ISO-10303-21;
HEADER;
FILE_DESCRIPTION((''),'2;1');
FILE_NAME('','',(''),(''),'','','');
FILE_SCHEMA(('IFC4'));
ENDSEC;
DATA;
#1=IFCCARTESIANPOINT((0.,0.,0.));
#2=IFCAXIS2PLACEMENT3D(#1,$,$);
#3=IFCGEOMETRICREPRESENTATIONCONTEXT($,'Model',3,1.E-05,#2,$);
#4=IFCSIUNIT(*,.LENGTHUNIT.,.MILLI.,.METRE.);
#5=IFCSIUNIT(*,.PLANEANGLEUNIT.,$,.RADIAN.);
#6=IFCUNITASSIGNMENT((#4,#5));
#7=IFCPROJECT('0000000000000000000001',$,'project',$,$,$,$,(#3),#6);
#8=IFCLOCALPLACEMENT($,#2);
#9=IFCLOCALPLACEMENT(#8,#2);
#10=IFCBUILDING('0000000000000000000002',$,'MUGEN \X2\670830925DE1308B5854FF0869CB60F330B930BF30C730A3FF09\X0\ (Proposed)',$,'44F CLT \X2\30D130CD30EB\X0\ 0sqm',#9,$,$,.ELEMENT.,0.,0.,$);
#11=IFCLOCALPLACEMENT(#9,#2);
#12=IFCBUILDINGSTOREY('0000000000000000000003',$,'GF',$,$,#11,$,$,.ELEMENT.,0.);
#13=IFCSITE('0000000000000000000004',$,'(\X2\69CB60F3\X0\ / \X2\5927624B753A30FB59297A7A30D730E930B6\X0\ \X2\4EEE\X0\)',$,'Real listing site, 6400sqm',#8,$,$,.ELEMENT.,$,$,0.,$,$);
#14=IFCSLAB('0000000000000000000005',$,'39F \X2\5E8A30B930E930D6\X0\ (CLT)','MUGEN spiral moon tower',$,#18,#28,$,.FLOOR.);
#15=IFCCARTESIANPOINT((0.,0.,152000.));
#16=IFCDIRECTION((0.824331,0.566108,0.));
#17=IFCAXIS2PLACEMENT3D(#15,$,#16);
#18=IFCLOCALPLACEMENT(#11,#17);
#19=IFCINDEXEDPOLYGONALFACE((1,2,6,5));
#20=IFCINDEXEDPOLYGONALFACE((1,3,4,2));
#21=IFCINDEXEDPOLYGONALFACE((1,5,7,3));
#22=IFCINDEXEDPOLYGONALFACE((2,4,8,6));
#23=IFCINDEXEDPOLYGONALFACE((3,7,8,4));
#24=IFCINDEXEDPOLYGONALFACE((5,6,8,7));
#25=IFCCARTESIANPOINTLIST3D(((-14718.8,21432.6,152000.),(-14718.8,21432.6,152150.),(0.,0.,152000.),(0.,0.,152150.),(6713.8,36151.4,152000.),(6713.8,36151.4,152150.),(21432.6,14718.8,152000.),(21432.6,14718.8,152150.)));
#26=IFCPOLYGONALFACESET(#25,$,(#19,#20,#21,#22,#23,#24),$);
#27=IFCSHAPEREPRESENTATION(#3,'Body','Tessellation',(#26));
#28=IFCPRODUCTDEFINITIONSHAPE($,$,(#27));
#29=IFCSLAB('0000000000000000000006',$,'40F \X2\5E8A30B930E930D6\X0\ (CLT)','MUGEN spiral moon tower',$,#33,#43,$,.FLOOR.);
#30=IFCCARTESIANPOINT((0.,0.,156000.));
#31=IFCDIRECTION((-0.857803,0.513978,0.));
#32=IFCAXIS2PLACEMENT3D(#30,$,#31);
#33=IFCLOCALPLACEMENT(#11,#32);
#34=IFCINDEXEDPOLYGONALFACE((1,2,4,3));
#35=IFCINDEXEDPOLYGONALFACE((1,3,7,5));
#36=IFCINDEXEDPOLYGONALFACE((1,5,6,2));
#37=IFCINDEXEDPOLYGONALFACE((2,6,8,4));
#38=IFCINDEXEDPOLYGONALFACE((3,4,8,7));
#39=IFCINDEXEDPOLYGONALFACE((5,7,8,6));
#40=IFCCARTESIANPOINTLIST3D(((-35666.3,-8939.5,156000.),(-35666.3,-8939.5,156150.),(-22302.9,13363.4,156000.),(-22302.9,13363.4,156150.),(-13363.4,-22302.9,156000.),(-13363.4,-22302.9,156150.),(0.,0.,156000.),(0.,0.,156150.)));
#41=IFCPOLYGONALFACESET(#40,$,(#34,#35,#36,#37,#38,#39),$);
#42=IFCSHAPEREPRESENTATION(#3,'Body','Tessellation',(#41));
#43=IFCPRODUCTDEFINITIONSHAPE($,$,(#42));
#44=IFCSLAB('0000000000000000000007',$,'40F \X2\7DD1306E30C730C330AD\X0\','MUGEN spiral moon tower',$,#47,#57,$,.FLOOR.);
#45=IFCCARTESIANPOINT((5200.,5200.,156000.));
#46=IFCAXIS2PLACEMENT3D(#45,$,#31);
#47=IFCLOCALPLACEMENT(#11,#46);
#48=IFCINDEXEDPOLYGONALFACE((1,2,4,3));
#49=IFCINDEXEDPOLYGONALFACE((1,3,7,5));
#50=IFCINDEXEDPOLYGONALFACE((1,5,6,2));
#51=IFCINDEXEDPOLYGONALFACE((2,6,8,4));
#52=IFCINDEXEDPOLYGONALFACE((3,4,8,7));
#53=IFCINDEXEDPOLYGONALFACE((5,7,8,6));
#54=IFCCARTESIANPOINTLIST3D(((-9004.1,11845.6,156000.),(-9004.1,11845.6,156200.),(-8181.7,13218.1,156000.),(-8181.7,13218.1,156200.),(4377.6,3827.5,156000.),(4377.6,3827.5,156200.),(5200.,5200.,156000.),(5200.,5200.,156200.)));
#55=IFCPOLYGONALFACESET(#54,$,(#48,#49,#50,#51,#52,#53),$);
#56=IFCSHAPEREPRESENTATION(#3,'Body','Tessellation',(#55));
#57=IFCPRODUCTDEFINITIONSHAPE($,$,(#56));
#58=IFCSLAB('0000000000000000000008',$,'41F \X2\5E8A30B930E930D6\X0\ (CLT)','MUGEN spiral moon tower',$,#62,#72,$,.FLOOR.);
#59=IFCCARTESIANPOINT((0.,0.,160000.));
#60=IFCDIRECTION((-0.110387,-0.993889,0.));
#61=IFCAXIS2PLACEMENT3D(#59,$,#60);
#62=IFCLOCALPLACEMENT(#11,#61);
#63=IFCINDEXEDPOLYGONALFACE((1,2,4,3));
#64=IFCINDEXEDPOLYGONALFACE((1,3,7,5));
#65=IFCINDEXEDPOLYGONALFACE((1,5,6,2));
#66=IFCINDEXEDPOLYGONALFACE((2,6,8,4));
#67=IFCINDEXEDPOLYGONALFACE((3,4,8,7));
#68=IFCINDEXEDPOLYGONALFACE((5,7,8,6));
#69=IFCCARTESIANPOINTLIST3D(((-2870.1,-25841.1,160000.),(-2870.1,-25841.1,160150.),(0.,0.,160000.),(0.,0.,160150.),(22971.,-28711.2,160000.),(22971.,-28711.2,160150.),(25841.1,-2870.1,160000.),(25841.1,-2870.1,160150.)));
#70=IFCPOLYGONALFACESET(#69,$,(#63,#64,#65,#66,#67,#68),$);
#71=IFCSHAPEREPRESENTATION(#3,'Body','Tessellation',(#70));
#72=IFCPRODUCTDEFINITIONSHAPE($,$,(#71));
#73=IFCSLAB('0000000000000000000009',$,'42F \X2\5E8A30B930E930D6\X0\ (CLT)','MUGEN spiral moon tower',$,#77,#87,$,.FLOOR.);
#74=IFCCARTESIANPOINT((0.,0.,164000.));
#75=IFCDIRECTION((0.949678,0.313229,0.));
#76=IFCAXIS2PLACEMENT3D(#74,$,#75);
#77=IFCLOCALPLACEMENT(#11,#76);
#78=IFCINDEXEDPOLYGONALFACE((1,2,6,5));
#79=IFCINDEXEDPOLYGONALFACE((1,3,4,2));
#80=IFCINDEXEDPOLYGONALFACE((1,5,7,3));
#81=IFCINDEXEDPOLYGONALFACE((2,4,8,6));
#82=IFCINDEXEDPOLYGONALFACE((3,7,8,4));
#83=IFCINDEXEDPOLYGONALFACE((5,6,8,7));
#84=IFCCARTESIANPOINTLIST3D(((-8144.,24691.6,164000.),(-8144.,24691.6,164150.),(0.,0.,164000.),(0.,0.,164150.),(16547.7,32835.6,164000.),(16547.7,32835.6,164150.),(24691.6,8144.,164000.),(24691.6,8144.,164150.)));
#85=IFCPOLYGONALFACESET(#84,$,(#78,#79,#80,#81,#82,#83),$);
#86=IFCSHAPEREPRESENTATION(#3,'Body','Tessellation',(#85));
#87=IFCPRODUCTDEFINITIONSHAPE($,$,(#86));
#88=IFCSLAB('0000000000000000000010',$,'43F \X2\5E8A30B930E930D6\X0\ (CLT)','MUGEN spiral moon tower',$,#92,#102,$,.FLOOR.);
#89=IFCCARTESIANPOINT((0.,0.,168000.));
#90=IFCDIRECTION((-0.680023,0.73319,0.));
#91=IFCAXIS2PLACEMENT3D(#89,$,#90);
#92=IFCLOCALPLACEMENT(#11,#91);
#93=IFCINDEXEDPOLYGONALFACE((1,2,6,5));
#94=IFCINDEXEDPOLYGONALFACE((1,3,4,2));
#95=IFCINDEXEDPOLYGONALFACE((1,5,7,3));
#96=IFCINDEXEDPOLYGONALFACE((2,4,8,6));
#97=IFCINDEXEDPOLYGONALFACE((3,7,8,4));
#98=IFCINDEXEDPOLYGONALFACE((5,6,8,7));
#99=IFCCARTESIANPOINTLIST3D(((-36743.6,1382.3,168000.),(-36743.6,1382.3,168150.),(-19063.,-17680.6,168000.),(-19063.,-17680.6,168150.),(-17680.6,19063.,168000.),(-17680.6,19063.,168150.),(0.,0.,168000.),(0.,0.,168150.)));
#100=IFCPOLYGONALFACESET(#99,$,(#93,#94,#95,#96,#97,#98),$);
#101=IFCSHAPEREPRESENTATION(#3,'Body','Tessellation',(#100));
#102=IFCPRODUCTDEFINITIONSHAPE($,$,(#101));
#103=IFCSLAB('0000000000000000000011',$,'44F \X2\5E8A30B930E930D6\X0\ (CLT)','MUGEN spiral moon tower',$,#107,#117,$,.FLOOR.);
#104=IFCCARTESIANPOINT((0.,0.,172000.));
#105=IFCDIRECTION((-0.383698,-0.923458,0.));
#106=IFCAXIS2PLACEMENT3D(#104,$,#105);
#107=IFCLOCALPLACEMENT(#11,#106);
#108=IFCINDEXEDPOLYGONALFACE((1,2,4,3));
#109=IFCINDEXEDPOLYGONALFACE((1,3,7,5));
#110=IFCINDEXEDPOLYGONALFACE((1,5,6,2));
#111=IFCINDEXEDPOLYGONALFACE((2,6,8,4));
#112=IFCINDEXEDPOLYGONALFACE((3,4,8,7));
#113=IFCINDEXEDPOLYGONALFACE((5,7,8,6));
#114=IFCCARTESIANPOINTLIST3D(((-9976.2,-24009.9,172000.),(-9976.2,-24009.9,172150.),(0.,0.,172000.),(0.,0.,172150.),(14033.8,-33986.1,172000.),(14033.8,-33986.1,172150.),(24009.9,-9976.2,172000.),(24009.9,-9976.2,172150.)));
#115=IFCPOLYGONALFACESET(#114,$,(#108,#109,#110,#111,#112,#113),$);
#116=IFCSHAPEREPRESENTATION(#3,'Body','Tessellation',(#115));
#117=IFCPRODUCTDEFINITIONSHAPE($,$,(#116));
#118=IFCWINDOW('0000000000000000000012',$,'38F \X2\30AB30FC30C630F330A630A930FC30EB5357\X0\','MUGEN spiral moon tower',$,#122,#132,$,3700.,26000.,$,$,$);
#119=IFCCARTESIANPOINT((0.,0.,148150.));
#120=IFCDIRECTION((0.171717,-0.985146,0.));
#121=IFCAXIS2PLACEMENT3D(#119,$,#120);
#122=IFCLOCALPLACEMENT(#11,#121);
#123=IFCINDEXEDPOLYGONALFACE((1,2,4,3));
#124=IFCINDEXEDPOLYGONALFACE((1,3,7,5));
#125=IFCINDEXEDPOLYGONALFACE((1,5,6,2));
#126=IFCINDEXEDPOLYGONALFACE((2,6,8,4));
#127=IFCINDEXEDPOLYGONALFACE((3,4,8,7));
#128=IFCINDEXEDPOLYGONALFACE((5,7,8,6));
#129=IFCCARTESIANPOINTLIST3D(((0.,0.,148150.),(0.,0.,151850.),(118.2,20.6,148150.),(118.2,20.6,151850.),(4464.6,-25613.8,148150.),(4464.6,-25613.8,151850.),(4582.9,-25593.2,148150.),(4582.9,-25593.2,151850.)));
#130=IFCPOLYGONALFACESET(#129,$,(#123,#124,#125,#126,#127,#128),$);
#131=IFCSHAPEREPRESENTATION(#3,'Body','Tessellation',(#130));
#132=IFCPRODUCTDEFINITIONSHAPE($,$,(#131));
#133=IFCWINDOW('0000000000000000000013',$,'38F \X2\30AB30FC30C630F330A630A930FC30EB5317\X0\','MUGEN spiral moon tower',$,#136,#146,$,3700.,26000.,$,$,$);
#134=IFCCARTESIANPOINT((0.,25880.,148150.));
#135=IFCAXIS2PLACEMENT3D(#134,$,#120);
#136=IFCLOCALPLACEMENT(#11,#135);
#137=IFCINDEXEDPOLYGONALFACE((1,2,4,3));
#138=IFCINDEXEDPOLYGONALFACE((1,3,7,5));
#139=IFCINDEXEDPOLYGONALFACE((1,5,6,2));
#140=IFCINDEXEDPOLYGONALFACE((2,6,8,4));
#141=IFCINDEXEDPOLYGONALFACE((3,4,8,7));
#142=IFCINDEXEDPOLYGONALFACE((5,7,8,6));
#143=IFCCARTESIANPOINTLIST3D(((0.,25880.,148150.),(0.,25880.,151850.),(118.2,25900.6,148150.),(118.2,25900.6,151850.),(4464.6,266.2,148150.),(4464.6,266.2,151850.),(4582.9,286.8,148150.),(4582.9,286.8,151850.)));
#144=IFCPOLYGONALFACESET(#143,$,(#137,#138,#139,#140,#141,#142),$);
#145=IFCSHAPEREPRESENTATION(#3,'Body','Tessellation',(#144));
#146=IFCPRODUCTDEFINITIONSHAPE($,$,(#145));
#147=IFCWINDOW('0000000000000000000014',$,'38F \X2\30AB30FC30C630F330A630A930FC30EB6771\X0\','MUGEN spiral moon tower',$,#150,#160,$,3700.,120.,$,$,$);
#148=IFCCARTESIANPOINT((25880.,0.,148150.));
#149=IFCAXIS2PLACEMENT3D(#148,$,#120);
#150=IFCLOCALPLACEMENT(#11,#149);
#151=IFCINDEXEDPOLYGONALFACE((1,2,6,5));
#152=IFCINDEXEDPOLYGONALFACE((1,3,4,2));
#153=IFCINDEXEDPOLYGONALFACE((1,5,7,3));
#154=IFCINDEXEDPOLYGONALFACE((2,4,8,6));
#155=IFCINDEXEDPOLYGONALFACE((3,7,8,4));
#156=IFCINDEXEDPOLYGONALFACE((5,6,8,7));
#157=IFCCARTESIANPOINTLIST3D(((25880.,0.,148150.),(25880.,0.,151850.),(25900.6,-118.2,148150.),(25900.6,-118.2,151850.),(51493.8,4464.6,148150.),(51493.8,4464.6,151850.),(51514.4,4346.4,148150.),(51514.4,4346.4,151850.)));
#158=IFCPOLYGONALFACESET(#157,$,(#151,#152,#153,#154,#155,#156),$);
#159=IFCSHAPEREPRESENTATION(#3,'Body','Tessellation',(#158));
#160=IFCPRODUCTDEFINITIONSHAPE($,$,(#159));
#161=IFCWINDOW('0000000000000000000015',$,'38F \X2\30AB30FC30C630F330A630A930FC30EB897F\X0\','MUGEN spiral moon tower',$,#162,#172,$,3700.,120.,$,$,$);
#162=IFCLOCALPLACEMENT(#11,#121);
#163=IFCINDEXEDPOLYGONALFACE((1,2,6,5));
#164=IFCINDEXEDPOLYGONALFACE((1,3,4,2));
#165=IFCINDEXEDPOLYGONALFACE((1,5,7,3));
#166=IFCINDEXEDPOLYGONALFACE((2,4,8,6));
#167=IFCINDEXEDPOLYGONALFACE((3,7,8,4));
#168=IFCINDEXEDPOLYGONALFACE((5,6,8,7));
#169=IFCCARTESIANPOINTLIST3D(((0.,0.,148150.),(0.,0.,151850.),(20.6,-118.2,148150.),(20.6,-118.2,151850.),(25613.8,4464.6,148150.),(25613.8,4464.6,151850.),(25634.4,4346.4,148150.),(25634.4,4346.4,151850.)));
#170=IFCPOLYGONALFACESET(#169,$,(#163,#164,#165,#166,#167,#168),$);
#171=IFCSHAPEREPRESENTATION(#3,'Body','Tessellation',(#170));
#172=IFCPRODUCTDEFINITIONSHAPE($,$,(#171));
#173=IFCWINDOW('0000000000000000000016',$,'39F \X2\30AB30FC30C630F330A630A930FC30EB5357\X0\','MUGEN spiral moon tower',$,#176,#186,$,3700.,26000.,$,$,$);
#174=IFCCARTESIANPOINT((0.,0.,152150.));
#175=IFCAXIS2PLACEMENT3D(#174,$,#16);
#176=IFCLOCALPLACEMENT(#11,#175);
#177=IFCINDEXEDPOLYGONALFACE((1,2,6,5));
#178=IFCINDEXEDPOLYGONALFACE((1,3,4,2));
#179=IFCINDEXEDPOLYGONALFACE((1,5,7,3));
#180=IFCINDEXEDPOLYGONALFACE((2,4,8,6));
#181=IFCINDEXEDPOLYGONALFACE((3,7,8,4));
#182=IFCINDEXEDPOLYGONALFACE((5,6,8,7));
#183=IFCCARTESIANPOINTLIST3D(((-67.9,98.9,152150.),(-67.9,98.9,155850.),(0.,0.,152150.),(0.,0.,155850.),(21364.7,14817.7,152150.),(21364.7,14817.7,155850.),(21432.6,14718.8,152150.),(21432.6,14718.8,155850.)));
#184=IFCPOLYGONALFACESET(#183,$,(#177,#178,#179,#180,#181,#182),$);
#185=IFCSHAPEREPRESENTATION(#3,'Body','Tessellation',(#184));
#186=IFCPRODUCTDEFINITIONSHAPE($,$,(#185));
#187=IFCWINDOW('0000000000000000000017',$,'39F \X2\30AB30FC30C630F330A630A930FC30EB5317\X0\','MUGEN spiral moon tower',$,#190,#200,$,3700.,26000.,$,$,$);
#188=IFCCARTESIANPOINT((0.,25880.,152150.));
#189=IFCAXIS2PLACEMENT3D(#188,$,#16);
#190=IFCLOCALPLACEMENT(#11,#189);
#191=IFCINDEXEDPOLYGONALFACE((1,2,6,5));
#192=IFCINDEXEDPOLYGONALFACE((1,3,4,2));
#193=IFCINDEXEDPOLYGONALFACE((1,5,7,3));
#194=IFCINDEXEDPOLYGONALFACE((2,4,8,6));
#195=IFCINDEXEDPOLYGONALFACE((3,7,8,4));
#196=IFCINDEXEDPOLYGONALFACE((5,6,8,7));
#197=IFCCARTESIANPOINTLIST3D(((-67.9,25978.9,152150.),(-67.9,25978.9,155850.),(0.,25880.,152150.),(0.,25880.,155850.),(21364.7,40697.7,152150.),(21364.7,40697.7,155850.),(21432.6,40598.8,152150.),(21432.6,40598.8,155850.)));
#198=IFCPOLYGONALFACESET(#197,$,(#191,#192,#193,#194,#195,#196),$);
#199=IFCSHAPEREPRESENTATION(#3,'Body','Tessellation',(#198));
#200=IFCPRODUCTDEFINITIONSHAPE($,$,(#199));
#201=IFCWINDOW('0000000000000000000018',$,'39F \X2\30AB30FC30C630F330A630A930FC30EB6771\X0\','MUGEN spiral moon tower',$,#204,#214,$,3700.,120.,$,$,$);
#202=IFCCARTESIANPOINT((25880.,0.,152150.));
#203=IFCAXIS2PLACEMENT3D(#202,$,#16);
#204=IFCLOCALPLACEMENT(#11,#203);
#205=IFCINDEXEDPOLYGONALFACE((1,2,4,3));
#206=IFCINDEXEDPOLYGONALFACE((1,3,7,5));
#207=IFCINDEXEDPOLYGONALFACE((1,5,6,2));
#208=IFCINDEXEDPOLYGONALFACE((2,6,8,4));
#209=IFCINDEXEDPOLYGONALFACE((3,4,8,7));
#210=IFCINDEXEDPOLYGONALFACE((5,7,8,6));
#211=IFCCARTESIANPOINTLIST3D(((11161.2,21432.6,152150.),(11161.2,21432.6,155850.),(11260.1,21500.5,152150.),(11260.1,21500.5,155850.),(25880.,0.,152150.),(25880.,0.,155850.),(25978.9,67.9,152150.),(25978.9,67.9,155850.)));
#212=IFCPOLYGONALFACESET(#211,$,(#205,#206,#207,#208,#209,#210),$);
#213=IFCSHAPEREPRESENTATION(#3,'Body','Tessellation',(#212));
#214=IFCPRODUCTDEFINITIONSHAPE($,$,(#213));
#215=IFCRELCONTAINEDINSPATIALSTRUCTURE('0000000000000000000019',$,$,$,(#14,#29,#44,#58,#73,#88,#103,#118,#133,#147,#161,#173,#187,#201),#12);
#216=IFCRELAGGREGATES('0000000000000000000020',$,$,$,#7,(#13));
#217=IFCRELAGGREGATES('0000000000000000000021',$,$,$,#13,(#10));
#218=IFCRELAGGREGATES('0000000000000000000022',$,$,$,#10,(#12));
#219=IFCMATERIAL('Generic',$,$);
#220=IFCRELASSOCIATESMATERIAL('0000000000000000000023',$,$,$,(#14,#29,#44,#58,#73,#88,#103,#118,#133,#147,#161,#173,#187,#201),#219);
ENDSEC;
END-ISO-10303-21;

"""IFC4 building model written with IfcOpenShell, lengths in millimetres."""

from ifc_helpers import new_model, si_unit, frame, frame_2d, origin, place, context, project, spatial, rectangle, extrude, material, element, save


model = new_model("IFC4")

# Units and contexts
model_context = context("Model", 3, precision=1e-05, world=origin())
ifc_project = project(units=[si_unit("LENGTHUNIT", "METRE", prefix="MILLI"), si_unit("PLANEANGLEUNIT", "RADIAN")], contexts=[model_context])

# Site, building, storey
site_placement = place(None, origin())
site = spatial("IfcSite", under=ifc_project, at=site_placement, Name="(構想 / 大手町・天空プラザ 仮)", ObjectType="Real listing site, 6400sqm", CompositionType="ELEMENT", RefElevation=0.0)
building_placement = place(site_placement, origin())
building = spatial("IfcBuilding", under=site, at=building_placement, Name="MUGEN 月を巡る塔（構想スタディ） (Proposed)", ObjectType="44F CLT パネル 0sqm", CompositionType="ELEMENT", ElevationOfRefHeight=0.0, ElevationOfTerrain=0.0)
storey_placement = place(building_placement, origin())
storey = spatial("IfcBuildingStorey", under=building, at=storey_placement, Name="GF", CompositionType="ELEMENT", Elevation=0.0)

# Slabs
ifc_material = material(Name="Generic")
slab_1_placement = place(storey_placement, frame((0.0, 0.0, 152000.0), x_axis=(0.824331, 0.566108, 0.0)))
element("IfcSlab", 1, at=slab_1_placement, inside=storey, material=ifc_material, Name="39F 床スラブ (CLT)", Description="MUGEN spiral moon tower", PredefinedType="FLOOR", context=model_context, shape_type="SweptSolid", body=[
    extrude(rectangle(XDim=26000.0, YDim=26000.0, at=frame_2d((13000.0, 13000.0))), frame((0.0, 0.0, 152000.0), x_axis=(0.824331, 0.566108, 0.0)), (0.0, 0.0, 1.0), 150.0),
])
slab_2_placement = place(storey_placement, frame((0.0, 0.0, 156000.0), x_axis=(-0.857803, 0.513978, 0.0)))
element("IfcSlab", 2, at=slab_2_placement, inside=storey, material=ifc_material, Name="40F 床スラブ (CLT)", Description="MUGEN spiral moon tower", PredefinedType="FLOOR", context=model_context, shape_type="SweptSolid", body=[
    extrude(rectangle(XDim=26000.0, YDim=26000.0, at=frame_2d((13000.0, 13000.0))), frame((0.0, 0.0, 156000.0), x_axis=(-0.857803, 0.513978, 0.0)), (0.0, 0.0, 1.0), 150.0),
])
slab_3_placement = place(storey_placement, frame((5200.0, 5200.0, 156000.0), x_axis=(-0.857803, 0.513978, 0.0)))
element("IfcSlab", 3, at=slab_3_placement, inside=storey, material=ifc_material, Name="40F 緑のデッキ", Description="MUGEN spiral moon tower", PredefinedType="FLOOR", context=model_context, shape_type="SweptSolid", body=[
    extrude(rectangle(XDim=15600.0, YDim=1600.0, at=frame_2d((7800.0, 800.0))), frame((5200.0, 5200.0, 156000.0), x_axis=(-0.857803, 0.513978, 0.0)), (0.0, 0.0, 1.0), 200.0),
])
slab_4_placement = place(storey_placement, frame((0.0, 0.0, 160000.0), x_axis=(-0.110387, -0.993889, 0.0)))
element("IfcSlab", 4, at=slab_4_placement, inside=storey, material=ifc_material, Name="41F 床スラブ (CLT)", Description="MUGEN spiral moon tower", PredefinedType="FLOOR", context=model_context, shape_type="SweptSolid", body=[
    extrude(rectangle(XDim=26000.0, YDim=26000.0, at=frame_2d((13000.0, 13000.0))), frame((0.0, 0.0, 160000.0), x_axis=(-0.110387, -0.993889, 0.0)), (0.0, 0.0, 1.0), 150.0),
])
slab_5_placement = place(storey_placement, frame((0.0, 0.0, 164000.0), x_axis=(0.949678, 0.313229, 0.0)))
element("IfcSlab", 5, at=slab_5_placement, inside=storey, material=ifc_material, Name="42F 床スラブ (CLT)", Description="MUGEN spiral moon tower", PredefinedType="FLOOR", context=model_context, shape_type="SweptSolid", body=[
    extrude(rectangle(XDim=26000.0, YDim=26000.0, at=frame_2d((13000.0, 13000.0))), frame((0.0, 0.0, 164000.0), x_axis=(0.949678, 0.313229, 0.0)), (0.0, 0.0, 1.0), 150.0),
])
slab_6_placement = place(storey_placement, frame((0.0, 0.0, 168000.0), x_axis=(-0.680023, 0.73319, 0.0)))
element("IfcSlab", 6, at=slab_6_placement, inside=storey, material=ifc_material, Name="43F 床スラブ (CLT)", Description="MUGEN spiral moon tower", PredefinedType="FLOOR", context=model_context, shape_type="SweptSolid", body=[
    extrude(rectangle(XDim=26000.0, YDim=26000.0, at=frame_2d((13000.0, 13000.0))), frame((0.0, 0.0, 168000.0), x_axis=(-0.680023, 0.73319, 0.0)), (0.0, 0.0, 1.0), 150.0),
])
slab_7_placement = place(storey_placement, frame((0.0, 0.0, 172000.0), x_axis=(-0.383698, -0.923458, 0.0)))
element("IfcSlab", 7, at=slab_7_placement, inside=storey, material=ifc_material, Name="44F 床スラブ (CLT)", Description="MUGEN spiral moon tower", PredefinedType="FLOOR", context=model_context, shape_type="SweptSolid", body=[
    extrude(rectangle(XDim=26000.0, YDim=26000.0, at=frame_2d((13000.0, 13000.0))), frame((0.0, 0.0, 172000.0), x_axis=(-0.383698, -0.923458, 0.0)), (0.0, 0.0, 1.0), 150.0),
])

# Windows
window_1_placement = place(storey_placement, frame((0.0, 0.0, 148150.0), x_axis=(0.171717, -0.985146, 0.0)))
element("IfcWindow", 8, at=window_1_placement, inside=storey, material=ifc_material, Name="38F カーテンウォール南", Description="MUGEN spiral moon tower", OverallHeight=3700.0, OverallWidth=26000.0, context=model_context, shape_type="SweptSolid", body=[
    extrude(rectangle(XDim=26000.0, YDim=120.0, at=frame_2d((13000.0, 60.0))), frame((0.0, 0.0, 148150.0), x_axis=(0.171717, -0.985146, 0.0)), (0.0, 0.0, 1.0), 3700.0),
])
window_2_placement = place(storey_placement, frame((0.0, 25880.0, 148150.0), x_axis=(0.171717, -0.985146, 0.0)))
element("IfcWindow", 9, at=window_2_placement, inside=storey, material=ifc_material, Name="38F カーテンウォール北", Description="MUGEN spiral moon tower", OverallHeight=3700.0, OverallWidth=26000.0, context=model_context, shape_type="SweptSolid", body=[
    extrude(rectangle(XDim=26000.0, YDim=120.0, at=frame_2d((13000.0, 60.0))), frame((0.0, 25880.0, 148150.0), x_axis=(0.171717, -0.985146, 0.0)), (0.0, 0.0, 1.0), 3700.0),
])
window_3_placement = place(storey_placement, frame((25880.0, 0.0, 148150.0), x_axis=(0.171717, -0.985146, 0.0)))
element("IfcWindow", 10, at=window_3_placement, inside=storey, material=ifc_material, Name="38F カーテンウォール東", Description="MUGEN spiral moon tower", OverallHeight=3700.0, OverallWidth=120.0, context=model_context, shape_type="SweptSolid", body=[
    extrude(rectangle(XDim=120.0, YDim=26000.0, at=frame_2d((60.0, 13000.0))), frame((25880.0, 0.0, 148150.0), x_axis=(0.171717, -0.985146, 0.0)), (0.0, 0.0, 1.0), 3700.0),
])
window_4_placement = place(storey_placement, frame((0.0, 0.0, 148150.0), x_axis=(0.171717, -0.985146, 0.0)))
element("IfcWindow", 11, at=window_4_placement, inside=storey, material=ifc_material, Name="38F カーテンウォール西", Description="MUGEN spiral moon tower", OverallHeight=3700.0, OverallWidth=120.0, context=model_context, shape_type="SweptSolid", body=[
    extrude(rectangle(XDim=120.0, YDim=26000.0, at=frame_2d((60.0, 13000.0))), frame((0.0, 0.0, 148150.0), x_axis=(0.171717, -0.985146, 0.0)), (0.0, 0.0, 1.0), 3700.0),
])
window_5_placement = place(storey_placement, frame((0.0, 0.0, 152150.0), x_axis=(0.824331, 0.566108, 0.0)))
element("IfcWindow", 12, at=window_5_placement, inside=storey, material=ifc_material, Name="39F カーテンウォール南", Description="MUGEN spiral moon tower", OverallHeight=3700.0, OverallWidth=26000.0, context=model_context, shape_type="SweptSolid", body=[
    extrude(rectangle(XDim=26000.0, YDim=120.0, at=frame_2d((13000.0, 60.0))), frame((0.0, 0.0, 152150.0), x_axis=(0.824331, 0.566108, 0.0)), (0.0, 0.0, 1.0), 3700.0),
])
window_6_placement = place(storey_placement, frame((0.0, 25880.0, 152150.0), x_axis=(0.824331, 0.566108, 0.0)))
element("IfcWindow", 13, at=window_6_placement, inside=storey, material=ifc_material, Name="39F カーテンウォール北", Description="MUGEN spiral moon tower", OverallHeight=3700.0, OverallWidth=26000.0, context=model_context, shape_type="SweptSolid", body=[
    extrude(rectangle(XDim=26000.0, YDim=120.0, at=frame_2d((13000.0, 60.0))), frame((0.0, 25880.0, 152150.0), x_axis=(0.824331, 0.566108, 0.0)), (0.0, 0.0, 1.0), 3700.0),
])
window_7_placement = place(storey_placement, frame((25880.0, 0.0, 152150.0), x_axis=(0.824331, 0.566108, 0.0)))
element("IfcWindow", 14, at=window_7_placement, inside=storey, material=ifc_material, Name="39F カーテンウォール東", Description="MUGEN spiral moon tower", OverallHeight=3700.0, OverallWidth=120.0, context=model_context, shape_type="SweptSolid", body=[
    extrude(rectangle(XDim=120.0, YDim=26000.0, at=frame_2d((60.0, 13000.0))), frame((25880.0, 0.0, 152150.0), x_axis=(0.824331, 0.566108, 0.0)), (0.0, 0.0, 1.0), 3700.0),
])

save(model, "model.ifc")
